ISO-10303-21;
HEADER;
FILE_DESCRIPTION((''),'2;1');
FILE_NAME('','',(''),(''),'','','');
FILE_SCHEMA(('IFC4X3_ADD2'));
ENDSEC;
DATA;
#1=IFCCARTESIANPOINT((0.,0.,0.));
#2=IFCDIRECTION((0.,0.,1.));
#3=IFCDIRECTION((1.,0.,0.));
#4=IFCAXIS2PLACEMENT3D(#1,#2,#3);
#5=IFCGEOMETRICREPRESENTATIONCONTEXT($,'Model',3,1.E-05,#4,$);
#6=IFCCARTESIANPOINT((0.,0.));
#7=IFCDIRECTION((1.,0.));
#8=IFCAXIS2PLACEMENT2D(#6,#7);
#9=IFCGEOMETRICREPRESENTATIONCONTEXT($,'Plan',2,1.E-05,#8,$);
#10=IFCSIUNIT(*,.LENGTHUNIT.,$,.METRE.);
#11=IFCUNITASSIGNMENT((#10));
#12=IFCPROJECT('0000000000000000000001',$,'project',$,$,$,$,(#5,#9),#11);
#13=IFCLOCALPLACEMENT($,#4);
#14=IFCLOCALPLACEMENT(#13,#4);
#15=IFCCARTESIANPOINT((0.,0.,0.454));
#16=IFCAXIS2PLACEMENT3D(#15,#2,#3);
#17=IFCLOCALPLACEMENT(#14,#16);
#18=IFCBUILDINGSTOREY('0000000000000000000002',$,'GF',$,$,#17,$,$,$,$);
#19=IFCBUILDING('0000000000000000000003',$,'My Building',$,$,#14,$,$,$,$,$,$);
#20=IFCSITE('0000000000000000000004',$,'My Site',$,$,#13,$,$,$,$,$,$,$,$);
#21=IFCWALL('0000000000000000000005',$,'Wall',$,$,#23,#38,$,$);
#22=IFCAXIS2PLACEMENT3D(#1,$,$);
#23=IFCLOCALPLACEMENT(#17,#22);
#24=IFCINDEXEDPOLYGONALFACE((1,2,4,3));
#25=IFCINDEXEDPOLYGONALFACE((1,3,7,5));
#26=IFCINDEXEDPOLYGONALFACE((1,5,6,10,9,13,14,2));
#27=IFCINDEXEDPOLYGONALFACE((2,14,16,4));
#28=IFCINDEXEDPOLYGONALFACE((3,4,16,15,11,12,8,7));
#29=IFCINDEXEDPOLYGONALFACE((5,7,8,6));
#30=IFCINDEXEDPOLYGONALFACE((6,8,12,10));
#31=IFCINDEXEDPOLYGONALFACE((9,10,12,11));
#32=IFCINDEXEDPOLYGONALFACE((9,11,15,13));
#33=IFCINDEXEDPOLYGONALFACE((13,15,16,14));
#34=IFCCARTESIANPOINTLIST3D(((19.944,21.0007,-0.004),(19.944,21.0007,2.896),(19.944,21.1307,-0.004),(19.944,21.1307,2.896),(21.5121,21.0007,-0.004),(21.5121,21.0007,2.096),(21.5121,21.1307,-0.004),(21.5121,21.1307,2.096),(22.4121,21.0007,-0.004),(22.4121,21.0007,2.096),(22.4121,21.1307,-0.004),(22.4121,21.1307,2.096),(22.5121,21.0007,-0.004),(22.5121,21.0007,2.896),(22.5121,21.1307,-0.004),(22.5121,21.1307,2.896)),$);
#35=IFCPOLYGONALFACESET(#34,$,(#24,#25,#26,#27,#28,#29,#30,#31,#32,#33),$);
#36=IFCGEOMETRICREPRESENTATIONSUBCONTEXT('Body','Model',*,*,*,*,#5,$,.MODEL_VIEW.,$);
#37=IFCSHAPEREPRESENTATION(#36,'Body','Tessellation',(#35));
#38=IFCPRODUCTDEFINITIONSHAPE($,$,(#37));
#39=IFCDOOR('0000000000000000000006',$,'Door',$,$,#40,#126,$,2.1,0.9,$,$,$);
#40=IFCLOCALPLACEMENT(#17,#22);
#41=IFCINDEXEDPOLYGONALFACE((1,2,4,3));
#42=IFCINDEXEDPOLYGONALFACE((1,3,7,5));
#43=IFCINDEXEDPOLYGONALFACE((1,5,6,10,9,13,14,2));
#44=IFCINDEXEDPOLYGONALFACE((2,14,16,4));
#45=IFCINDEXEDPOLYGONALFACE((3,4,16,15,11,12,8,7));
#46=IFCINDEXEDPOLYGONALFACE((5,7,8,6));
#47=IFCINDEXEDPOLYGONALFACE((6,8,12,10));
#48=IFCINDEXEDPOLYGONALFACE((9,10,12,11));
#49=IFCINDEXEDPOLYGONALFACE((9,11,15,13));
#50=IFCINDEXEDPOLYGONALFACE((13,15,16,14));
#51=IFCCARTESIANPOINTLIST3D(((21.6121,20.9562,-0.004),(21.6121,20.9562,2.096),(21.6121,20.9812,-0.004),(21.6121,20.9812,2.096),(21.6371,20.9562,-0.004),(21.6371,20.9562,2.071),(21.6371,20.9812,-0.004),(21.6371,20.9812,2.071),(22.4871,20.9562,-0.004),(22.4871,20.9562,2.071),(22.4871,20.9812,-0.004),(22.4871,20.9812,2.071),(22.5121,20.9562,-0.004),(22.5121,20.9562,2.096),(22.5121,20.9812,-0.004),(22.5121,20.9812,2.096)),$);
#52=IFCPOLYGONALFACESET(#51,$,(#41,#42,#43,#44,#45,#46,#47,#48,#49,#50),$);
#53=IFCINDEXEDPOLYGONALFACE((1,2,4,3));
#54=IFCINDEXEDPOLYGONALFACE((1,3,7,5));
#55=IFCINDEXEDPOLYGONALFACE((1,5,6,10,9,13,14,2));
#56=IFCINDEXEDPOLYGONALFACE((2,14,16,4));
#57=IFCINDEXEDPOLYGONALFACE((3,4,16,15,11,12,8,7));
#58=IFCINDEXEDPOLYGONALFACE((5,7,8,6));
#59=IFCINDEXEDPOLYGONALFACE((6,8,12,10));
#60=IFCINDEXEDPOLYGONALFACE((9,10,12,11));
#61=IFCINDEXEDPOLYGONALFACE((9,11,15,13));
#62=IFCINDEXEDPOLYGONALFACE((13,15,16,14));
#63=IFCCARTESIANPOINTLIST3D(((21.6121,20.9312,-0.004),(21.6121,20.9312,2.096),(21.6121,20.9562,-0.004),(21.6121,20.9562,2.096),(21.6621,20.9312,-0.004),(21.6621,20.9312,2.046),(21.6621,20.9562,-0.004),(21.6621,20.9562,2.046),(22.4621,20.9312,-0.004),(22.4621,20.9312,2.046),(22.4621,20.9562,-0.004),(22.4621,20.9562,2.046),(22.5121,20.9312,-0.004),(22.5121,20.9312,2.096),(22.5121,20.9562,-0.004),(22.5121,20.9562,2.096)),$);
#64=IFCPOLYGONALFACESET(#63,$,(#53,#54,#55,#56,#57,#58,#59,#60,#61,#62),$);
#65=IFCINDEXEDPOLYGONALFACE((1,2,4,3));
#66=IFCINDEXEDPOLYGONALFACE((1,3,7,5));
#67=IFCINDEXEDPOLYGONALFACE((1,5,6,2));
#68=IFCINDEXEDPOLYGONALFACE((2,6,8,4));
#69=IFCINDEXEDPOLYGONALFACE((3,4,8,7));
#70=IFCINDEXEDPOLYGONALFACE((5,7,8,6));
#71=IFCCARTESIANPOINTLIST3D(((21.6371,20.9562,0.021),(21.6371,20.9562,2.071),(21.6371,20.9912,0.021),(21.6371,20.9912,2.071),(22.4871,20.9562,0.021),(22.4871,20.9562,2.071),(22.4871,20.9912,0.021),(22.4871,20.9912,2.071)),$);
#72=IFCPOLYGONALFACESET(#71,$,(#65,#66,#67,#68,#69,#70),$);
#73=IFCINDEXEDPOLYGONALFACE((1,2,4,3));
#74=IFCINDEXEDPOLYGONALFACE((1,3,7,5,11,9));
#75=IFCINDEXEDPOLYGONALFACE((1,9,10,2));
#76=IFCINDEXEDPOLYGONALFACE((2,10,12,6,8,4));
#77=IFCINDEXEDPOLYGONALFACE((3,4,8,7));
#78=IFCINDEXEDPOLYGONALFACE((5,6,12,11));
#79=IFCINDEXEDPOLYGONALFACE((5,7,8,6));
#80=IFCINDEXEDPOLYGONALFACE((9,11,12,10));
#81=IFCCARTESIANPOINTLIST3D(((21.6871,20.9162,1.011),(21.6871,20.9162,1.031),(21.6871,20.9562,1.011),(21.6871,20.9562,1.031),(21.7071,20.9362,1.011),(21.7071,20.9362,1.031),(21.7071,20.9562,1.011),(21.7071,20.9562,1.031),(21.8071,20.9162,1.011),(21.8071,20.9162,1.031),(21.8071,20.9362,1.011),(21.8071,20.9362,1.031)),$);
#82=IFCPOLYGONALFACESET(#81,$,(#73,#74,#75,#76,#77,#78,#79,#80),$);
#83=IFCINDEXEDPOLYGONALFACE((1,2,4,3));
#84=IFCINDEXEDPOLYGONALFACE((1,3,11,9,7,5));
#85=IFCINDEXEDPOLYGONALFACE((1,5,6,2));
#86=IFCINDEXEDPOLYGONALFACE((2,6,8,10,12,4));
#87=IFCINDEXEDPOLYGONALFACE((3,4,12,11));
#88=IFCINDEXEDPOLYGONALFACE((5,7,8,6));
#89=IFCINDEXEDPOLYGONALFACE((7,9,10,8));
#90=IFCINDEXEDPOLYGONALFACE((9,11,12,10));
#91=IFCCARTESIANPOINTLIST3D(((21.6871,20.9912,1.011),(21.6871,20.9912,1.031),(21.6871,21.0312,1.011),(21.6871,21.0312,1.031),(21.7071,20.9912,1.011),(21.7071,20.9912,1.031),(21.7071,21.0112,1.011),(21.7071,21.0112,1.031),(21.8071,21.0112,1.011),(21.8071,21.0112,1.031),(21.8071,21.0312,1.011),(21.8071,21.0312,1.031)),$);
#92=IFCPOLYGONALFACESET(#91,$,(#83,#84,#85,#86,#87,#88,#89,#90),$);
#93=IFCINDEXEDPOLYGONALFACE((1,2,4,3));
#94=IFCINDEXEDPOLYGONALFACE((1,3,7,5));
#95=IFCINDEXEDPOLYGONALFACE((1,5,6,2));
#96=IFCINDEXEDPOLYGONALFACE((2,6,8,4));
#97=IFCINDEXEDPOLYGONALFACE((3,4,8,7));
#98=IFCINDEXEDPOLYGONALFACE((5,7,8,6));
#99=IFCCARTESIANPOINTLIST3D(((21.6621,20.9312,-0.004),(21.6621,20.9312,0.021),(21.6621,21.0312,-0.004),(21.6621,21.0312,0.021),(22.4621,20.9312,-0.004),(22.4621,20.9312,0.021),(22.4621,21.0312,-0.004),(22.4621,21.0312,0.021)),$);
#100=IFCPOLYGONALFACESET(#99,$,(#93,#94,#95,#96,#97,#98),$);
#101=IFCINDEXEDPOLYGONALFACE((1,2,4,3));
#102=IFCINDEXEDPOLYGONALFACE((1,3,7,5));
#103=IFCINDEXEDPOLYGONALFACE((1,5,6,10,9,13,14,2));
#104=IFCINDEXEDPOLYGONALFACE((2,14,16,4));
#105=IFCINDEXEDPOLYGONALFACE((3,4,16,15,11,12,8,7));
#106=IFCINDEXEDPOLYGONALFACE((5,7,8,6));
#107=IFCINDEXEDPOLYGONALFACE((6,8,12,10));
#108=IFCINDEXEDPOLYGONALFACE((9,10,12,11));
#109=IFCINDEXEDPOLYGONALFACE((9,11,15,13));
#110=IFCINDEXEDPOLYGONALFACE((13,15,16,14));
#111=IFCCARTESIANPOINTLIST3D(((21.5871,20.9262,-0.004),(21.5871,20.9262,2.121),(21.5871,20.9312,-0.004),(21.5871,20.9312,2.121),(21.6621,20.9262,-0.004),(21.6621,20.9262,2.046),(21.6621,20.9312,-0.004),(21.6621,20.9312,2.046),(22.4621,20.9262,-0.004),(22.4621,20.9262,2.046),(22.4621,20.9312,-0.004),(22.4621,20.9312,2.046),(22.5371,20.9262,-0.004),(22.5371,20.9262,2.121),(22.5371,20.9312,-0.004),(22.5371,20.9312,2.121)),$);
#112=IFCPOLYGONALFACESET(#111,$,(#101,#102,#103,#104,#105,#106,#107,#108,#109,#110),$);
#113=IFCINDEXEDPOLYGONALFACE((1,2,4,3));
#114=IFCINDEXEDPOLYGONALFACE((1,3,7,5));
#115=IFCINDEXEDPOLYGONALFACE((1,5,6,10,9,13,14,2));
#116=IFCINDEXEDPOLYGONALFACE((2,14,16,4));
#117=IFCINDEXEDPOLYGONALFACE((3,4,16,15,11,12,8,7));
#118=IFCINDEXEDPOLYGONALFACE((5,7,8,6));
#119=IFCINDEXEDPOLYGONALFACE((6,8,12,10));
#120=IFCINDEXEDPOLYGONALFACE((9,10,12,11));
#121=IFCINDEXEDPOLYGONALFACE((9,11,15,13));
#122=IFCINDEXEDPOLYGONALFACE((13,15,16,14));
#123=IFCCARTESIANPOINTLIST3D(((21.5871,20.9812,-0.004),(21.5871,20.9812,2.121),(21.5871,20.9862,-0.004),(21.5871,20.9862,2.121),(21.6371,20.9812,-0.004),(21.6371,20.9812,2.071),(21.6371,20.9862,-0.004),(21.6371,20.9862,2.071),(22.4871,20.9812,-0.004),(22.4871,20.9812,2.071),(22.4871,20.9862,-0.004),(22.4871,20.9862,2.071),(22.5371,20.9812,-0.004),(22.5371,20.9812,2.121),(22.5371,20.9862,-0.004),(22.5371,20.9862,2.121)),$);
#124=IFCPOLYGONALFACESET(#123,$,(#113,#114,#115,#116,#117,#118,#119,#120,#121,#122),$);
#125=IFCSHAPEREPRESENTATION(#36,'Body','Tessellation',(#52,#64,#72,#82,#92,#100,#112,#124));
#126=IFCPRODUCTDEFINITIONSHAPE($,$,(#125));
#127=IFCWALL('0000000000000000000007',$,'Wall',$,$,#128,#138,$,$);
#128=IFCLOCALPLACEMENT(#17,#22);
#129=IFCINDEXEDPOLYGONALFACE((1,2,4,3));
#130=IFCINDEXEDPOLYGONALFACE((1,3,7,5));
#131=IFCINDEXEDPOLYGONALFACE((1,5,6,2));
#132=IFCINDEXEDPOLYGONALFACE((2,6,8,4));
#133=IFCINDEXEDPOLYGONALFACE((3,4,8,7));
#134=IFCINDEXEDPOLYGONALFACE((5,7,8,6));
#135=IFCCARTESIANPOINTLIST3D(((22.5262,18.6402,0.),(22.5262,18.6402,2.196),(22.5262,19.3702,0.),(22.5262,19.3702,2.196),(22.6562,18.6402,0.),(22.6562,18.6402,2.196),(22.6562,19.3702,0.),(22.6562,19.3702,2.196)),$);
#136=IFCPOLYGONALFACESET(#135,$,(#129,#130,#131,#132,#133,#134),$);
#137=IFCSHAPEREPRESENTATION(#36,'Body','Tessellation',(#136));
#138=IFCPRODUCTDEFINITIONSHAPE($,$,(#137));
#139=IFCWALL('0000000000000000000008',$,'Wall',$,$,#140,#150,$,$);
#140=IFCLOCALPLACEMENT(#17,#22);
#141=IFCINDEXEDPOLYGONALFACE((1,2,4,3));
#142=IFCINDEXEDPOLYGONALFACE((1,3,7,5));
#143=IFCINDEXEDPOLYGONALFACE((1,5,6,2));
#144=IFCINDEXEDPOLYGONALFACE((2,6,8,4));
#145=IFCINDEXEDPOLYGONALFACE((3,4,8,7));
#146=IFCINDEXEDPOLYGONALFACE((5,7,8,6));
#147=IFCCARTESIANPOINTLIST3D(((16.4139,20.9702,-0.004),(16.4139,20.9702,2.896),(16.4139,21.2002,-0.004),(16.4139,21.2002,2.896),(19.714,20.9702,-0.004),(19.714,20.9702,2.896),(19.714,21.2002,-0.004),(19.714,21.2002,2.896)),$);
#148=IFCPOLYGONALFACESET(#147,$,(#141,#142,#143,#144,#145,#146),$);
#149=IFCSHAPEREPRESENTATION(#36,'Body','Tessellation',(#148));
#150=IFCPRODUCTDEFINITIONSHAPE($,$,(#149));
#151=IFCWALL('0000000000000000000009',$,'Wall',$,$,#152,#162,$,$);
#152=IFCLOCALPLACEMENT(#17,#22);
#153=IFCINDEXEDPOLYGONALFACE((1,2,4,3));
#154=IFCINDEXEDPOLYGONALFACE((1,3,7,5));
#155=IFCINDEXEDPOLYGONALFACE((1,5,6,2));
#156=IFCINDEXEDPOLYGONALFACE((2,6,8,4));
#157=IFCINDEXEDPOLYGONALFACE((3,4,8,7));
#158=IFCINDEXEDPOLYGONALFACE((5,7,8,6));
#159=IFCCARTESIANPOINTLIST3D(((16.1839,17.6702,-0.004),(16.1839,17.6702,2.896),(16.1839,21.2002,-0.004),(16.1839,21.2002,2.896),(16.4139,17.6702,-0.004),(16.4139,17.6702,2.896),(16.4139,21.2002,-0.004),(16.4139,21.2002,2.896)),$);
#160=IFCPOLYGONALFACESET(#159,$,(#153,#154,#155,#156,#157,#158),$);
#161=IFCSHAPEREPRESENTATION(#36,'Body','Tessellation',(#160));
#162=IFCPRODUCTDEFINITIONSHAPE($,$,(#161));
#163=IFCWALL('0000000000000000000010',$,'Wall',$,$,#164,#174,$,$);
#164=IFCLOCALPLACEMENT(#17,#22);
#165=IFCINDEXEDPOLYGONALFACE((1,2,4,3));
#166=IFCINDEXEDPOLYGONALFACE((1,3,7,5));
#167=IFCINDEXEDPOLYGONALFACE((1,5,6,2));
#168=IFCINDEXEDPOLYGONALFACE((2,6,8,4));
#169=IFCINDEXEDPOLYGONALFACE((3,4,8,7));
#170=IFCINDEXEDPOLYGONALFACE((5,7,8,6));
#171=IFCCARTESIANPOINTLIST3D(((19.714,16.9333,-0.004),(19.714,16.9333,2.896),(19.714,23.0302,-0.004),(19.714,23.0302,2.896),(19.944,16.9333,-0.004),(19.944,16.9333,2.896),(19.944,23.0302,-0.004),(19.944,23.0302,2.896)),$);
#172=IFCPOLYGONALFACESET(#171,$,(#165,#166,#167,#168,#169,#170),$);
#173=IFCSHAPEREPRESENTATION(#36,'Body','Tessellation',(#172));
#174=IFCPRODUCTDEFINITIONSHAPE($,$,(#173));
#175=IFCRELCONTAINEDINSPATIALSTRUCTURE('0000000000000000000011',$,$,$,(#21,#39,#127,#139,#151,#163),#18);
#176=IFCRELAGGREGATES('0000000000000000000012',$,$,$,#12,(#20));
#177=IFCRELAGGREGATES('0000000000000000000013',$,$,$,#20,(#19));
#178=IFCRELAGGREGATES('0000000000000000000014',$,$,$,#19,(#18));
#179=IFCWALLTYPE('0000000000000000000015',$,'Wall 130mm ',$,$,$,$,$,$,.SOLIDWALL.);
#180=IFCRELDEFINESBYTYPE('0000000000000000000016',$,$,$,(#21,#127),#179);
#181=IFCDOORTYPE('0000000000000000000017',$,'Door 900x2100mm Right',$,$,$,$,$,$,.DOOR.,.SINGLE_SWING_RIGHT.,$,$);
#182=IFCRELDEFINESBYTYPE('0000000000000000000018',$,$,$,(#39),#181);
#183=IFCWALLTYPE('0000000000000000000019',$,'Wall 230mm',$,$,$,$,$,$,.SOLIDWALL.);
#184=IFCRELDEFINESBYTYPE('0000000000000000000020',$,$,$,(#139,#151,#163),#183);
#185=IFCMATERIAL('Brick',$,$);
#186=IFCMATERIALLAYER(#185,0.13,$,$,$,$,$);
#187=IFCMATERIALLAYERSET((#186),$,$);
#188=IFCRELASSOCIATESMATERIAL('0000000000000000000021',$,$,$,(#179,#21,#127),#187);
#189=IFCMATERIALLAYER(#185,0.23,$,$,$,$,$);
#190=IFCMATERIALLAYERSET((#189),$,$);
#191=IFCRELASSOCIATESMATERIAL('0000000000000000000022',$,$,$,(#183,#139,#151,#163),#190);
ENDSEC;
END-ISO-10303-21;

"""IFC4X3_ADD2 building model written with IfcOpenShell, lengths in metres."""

from ifc_helpers import new_model, entity, si_unit, frame, origin_with_axes, origin_2d_with_axis, place, context, subcontext, project, spatial, line, indexed_curve, outline, extrude, clip, halfspace, shape, source, transform, mapped, material, layer, layer_set, layer_usage, type_object, type_shapes, element, fill, save


model = new_model("IFC4X3_ADD2")

# Units and contexts
model_context = context("Model", 3, precision=1e-05, world=origin_with_axes())
plan_context = context("Plan", 2, precision=1e-05, world=origin_2d_with_axis())
body_context_1 = subcontext(model_context, "Body", "Model", "MODEL_VIEW")
body_context_2 = subcontext(plan_context, "Body", "Plan", "PLAN_VIEW")
ifc_project = project(units=[si_unit("LENGTHUNIT", "METRE")], contexts=[model_context, plan_context])

# Site, building, storey
site_placement = place(None, origin_with_axes())
site = spatial("IfcSite", under=ifc_project, at=site_placement, Name="My Site")
building_placement = place(site_placement, origin_with_axes())
building = spatial("IfcBuilding", under=site, at=building_placement, Name="My Building")
storey_placement = place(building_placement, frame((0.0, 0.0, 0.454), z_axis=(0.0, 0.0, 1.0), x_axis=(1.0, 0.0, 0.0)))
storey = spatial("IfcBuildingStorey", under=building, at=storey_placement, Name="GF")

# Wall, opening, door
ifc_material_1 = material(Name="Brick")
ifc_layer_1 = layer(ifc_material_1, 0.13)
ifc_layer_set_1 = layer_set([ifc_layer_1])
ifc_layer_usage_1 = layer_usage(ifc_layer_set_1, "AXIS2", "POSITIVE", 0.0)
wall_type_1 = type_object("IfcWallType", Name="Wall 130mm ", PredefinedType="SOLIDWALL", material=ifc_layer_set_1)
wall_1_placement = place(storey_placement, frame((22.5121, 21.1307, -0.004), z_axis=(0.0, 0.0, 1.0), x_axis=(-1.0, 0.0, 0.0)))
wall_1 = element("IfcWall", 1, at=wall_1_placement, inside=storey, type_object=wall_type_1, material=ifc_layer_usage_1, Name="Wall", context=body_context_1, shape_type="SweptSolid", body=[
    extrude(outline(indexed_curve([(0.0, 0.0), (0.0, 0.13), (2.5681, 0.13), (2.5681, 0.0), (0.0, 0.0)], self_intersect=False)), origin_with_axes(), (0.0, 0.0, 1.0), 2.9),
])
shared_shape_1 = source(origin_with_axes(), body_context_1, "Body", "SweptSolid", [
    extrude(outline(indexed_curve([(0.0, 0.0), (0.9, 0.0), (0.9, 2.1), (0.0, 2.1)], segments=[line(1, 2, 3, 4, 1)])), frame((0.0, -0.6, 0.0), z_axis=(0.0, -1.0, 0.0), x_axis=(1.0, 0.0, 0.0)), (0.0, 0.0, -1.0), 1.2),
])
opening_1_placement = place(wall_1_placement, frame((1.0, 0.13, 0.0), z_axis=(0.0, 0.0, 1.0), x_axis=(-1.0, 0.0, 0.0)))
opening_1 = element("IfcOpeningElement", 2, at=opening_1_placement, cuts=wall_1, PredefinedType="OPENING", context=body_context_1, shape_type="MappedRepresentation", body=[
    mapped(shared_shape_1, transform((0.0, 0.0, 0.0), x_axis=(1.0, 0.0, 0.0), y_axis=(0.0, 1.0, 0.0), z_axis=(0.0, 0.0, 1.0), scale=1.0)),
])
door_type_1 = type_object("IfcDoorType", Name="Door 900x2100mm Right", OperationType="SINGLE_SWING_RIGHT", PredefinedType="DOOR")
shared_shape_2 = source(origin_with_axes(), body_context_1, "Body", "SweptSolid", [
    extrude(outline(indexed_curve([(0.0, 0.0), (0.0, 2.1), (0.9, 2.1), (0.9, 0.0), (0.875, 0.0), (0.875, 2.075), (0.025, 2.075), (0.025, 0.0)], segments=[line(1, 2, 3, 4, 5, 6, 7, 8, 1)])), frame((0.0, 0.025, 0.0), z_axis=(0.0, -1.0, 0.0), x_axis=(1.0, 0.0, 0.0)), (0.0, 0.0, -1.0), 0.025),
    extrude(outline(indexed_curve([(0.0, 0.0), (0.0, 2.1), (0.9, 2.1), (0.9, 0.0), (0.85, 0.0), (0.85, 2.05), (0.05, 2.05), (0.05, 0.0)], segments=[line(1, 2, 3, 4, 5, 6, 7, 8, 1)])), frame((0.0, 0.0, 0.0), z_axis=(0.0, -1.0, 0.0), x_axis=(1.0, 0.0, 0.0)), (0.0, 0.0, -1.0), 0.025),
    extrude(outline(indexed_curve([(0.0, 0.0), (0.85, 0.0), (0.85, 0.035), (0.0, 0.035)], segments=[line(1, 2, 3, 4, 1)])), frame((0.025, 0.025, 0.025), z_axis=(0.0, 0.0, 1.0), x_axis=(1.0, 0.0, 0.0)), (0.0, 0.0, 1.0), 2.05),
    extrude(outline(indexed_curve([(0.0, 0.0), (0.0, -0.04), (0.12, -0.04), (0.12, -0.02), (0.02, -0.02), (0.02, 0.0)], segments=[line(1, 2, 3, 4, 5, 6, 1)])), frame((0.075, 0.025, 1.015), z_axis=(0.0, 0.0, 1.0), x_axis=(1.0, 0.0, 0.0)), (0.0, 0.0, 1.0), 0.02),
    extrude(outline(indexed_curve([(0.0, 0.0), (0.0, 0.04), (0.12, 0.04), (0.12, 0.02), (0.02, 0.02), (0.02, 0.0)], segments=[line(1, 2, 3, 4, 5, 6, 1)])), frame((0.075, 0.06, 1.015), z_axis=(0.0, 0.0, 1.0), x_axis=(1.0, 0.0, 0.0)), (0.0, 0.0, 1.0), 0.02),
    extrude(outline(indexed_curve([(0.0, 0.0), (0.8, 0.0), (0.8, 0.1), (0.0, 0.1)], segments=[line(1, 2, 3, 4, 1)])), frame((0.05, 0.0, 0.0), z_axis=(0.0, 0.0, 1.0), x_axis=(1.0, 0.0, 0.0)), (0.0, 0.0, 1.0), 0.025),
    extrude(outline(indexed_curve([(0.0, 0.0), (0.0, 2.125), (0.95, 2.125), (0.95, 0.0), (0.875, 0.0), (0.875, 2.05), (0.075, 2.05), (0.075, 0.0)], segments=[line(1, 2, 3, 4, 5, 6, 7, 8, 1)])), frame((-0.025, -0.005, 0.0), z_axis=(0.0, -1.0, 0.0), x_axis=(1.0, 0.0, 0.0)), (0.0, 0.0, -1.0), 0.005),
    extrude(outline(indexed_curve([(0.0, 0.0), (0.0, 2.125), (0.95, 2.125), (0.95, 0.0), (0.9, 0.0), (0.9, 2.075), (0.05, 2.075), (0.05, 0.0)], segments=[line(1, 2, 3, 4, 5, 6, 7, 8, 1)])), frame((-0.025, 0.05, 0.0), z_axis=(0.0, -1.0, 0.0), x_axis=(1.0, 0.0, 0.0)), (0.0, 0.0, -1.0), 0.005),
])
shared_shape_3 = source(origin_with_axes(), body_context_2, "Body", "Curve2D", [
    entity("IfcIndexedPolyCurve", entity("IfcCartesianPointList2D", [[0.0, 0.0], [0.0, 0.05], [0.025, 0.05], [0.025, 0.025], [0.05, 0.025], [0.05, 0.0]]), [entity("IfcLineIndex", [1, 2, 3, 4, 5, 6, 1])]),
    entity("IfcIndexedPolyCurve", entity("IfcCartesianPointList2D", [[0.9, 0.0], [0.9, 0.05], [0.875, 0.05], [0.875, 0.025], [0.85, 0.025], [0.85, 0.0]]), [entity("IfcLineIndex", [1, 2, 3, 4, 5, 6, 1])]),
    entity("IfcTrimmedCurve", entity("IfcEllipse", entity("IfcAxis2Placement2D", entity("IfcCartesianPoint", [0.84, 0.05]), entity("IfcDirection", [1.0, 0.0])), 0.815, 0.85), [entity("IfcCartesianPoint", [0.84, 0.9])], [entity("IfcCartesianPoint", [0.025, 0.05])], True, "CARTESIAN"),
    entity("IfcIndexedPolyCurve", entity("IfcCartesianPointList2D", [[0.875, 0.05], [0.84, 0.05], [0.84, 0.9], [0.875, 0.9]]), [entity("IfcLineIndex", [1, 2, 3, 4, 1])]),
])
type_shapes(door_type_1, [shared_shape_2, shared_shape_3])
door_1_placement = place(opening_1_placement, frame((0.1, -0.0695, 0.0), z_axis=(0.0, 0.0, 1.0), x_axis=(1.0, 0.0, 0.0)))
door_1 = element("IfcDoor", 3, at=door_1_placement, inside=storey, type_object=door_type_1, Name="Door", OverallHeight=2.1, OverallWidth=0.9, shapes=[
    shape(body_context_1, "Body", "MappedRepresentation", [mapped(shared_shape_2, transform((0.0, 0.0, 0.0), x_axis=(1.0, 0.0, 0.0), y_axis=(0.0, 1.0, 0.0), z_axis=(0.0, 0.0, 1.0), scale=1.0))]),
    shape(body_context_2, "Body", "MappedRepresentation", [mapped(shared_shape_3, transform((0.0, 0.0, 0.0), x_axis=(1.0, 0.0, 0.0), y_axis=(0.0, 1.0, 0.0), z_axis=(0.0, 0.0, 1.0), scale=1.0))]),
])
fill(opening_1, door_1)

# Walls
ifc_layer_usage_2 = layer_usage(ifc_layer_set_1, "AXIS2", "POSITIVE", 0.0)
wall_2_placement = place(storey_placement, frame((22.6562, 18.6402, 0.0), z_axis=(0.0, 0.0, 1.0), x_axis=(0.000002, 1.0, 0.0)))
element("IfcWall", 4, at=wall_2_placement, inside=storey, type_object=wall_type_1, material=ifc_layer_usage_2, Name="Wall", context=body_context_1, shape_type="Clipping", body=[
    clip(extrude(outline(indexed_curve([(0.0, 0.0), (0.0, 0.13), (0.73, 0.13), (0.73, 0.0), (0.0, 0.0)], self_intersect=False)), origin_with_axes(), (0.0, 0.0, 1.0), 2.65), halfspace(frame((0.0, 0.0, 2.196), z_axis=(0.0, 0.0, 1.0), x_axis=(-1.0, 0.0, 0.0)), False)),
])
ifc_layer_2 = layer(ifc_material_1, 0.23)
ifc_layer_set_2 = layer_set([ifc_layer_2])
ifc_layer_usage_3 = layer_usage(ifc_layer_set_2, "AXIS2", "POSITIVE", 0.0)
wall_type_2 = type_object("IfcWallType", Name="Wall 230mm", PredefinedType="SOLIDWALL", material=ifc_layer_set_2)
wall_3_placement = place(storey_placement, frame((19.714, 21.2002, -0.004), z_axis=(0.0, 0.0, 1.0), x_axis=(-1.0, 0.0, 0.0)))
element("IfcWall", 5, at=wall_3_placement, inside=storey, type_object=wall_type_2, material=ifc_layer_usage_3, Name="Wall", context=body_context_1, shape_type="SweptSolid", body=[
    extrude(outline(indexed_curve([(0.0, 0.0), (0.0, 0.23), (3.3, 0.23), (3.3, 0.0), (0.0, 0.0)], self_intersect=False)), origin_with_axes(), (0.0, 0.0, 1.0), 2.9),
])
ifc_layer_usage_4 = layer_usage(ifc_layer_set_2, "AXIS2", "POSITIVE", 0.0)
wall_4_placement = place(storey_placement, frame((16.4139, 17.6702, -0.004), z_axis=(0.0, 0.0, 1.0), x_axis=(0.000001, 1.0, 0.0)))
element("IfcWall", 6, at=wall_4_placement, inside=storey, type_object=wall_type_2, material=ifc_layer_usage_4, Name="Wall", context=body_context_1, shape_type="SweptSolid", body=[
    extrude(outline(indexed_curve([(0.0, 0.0), (0.0, 0.23), (3.53, 0.23), (3.53, 0.0), (0.0, 0.0)], self_intersect=False)), origin_with_axes(), (0.0, 0.0, 1.0), 2.9),
])
ifc_layer_usage_5 = layer_usage(ifc_layer_set_2, "AXIS2", "POSITIVE", 0.0)
wall_5_placement = place(storey_placement, frame((19.944, 16.9333, -0.004), z_axis=(0.0, 0.0, 1.0), x_axis=(0.000001, 1.0, 0.0)))
element("IfcWall", 7, at=wall_5_placement, inside=storey, type_object=wall_type_2, material=ifc_layer_usage_5, Name="Wall", context=body_context_1, shape_type="SweptSolid", body=[
    extrude(outline(indexed_curve([(0.0, 0.0), (0.0, 0.23), (6.0969, 0.23), (6.0969, 0.0), (0.0, 0.0)], self_intersect=False)), origin_with_axes(), (0.0, 0.0, 1.0), 2.9),
])

save(model, "model.ifc")
